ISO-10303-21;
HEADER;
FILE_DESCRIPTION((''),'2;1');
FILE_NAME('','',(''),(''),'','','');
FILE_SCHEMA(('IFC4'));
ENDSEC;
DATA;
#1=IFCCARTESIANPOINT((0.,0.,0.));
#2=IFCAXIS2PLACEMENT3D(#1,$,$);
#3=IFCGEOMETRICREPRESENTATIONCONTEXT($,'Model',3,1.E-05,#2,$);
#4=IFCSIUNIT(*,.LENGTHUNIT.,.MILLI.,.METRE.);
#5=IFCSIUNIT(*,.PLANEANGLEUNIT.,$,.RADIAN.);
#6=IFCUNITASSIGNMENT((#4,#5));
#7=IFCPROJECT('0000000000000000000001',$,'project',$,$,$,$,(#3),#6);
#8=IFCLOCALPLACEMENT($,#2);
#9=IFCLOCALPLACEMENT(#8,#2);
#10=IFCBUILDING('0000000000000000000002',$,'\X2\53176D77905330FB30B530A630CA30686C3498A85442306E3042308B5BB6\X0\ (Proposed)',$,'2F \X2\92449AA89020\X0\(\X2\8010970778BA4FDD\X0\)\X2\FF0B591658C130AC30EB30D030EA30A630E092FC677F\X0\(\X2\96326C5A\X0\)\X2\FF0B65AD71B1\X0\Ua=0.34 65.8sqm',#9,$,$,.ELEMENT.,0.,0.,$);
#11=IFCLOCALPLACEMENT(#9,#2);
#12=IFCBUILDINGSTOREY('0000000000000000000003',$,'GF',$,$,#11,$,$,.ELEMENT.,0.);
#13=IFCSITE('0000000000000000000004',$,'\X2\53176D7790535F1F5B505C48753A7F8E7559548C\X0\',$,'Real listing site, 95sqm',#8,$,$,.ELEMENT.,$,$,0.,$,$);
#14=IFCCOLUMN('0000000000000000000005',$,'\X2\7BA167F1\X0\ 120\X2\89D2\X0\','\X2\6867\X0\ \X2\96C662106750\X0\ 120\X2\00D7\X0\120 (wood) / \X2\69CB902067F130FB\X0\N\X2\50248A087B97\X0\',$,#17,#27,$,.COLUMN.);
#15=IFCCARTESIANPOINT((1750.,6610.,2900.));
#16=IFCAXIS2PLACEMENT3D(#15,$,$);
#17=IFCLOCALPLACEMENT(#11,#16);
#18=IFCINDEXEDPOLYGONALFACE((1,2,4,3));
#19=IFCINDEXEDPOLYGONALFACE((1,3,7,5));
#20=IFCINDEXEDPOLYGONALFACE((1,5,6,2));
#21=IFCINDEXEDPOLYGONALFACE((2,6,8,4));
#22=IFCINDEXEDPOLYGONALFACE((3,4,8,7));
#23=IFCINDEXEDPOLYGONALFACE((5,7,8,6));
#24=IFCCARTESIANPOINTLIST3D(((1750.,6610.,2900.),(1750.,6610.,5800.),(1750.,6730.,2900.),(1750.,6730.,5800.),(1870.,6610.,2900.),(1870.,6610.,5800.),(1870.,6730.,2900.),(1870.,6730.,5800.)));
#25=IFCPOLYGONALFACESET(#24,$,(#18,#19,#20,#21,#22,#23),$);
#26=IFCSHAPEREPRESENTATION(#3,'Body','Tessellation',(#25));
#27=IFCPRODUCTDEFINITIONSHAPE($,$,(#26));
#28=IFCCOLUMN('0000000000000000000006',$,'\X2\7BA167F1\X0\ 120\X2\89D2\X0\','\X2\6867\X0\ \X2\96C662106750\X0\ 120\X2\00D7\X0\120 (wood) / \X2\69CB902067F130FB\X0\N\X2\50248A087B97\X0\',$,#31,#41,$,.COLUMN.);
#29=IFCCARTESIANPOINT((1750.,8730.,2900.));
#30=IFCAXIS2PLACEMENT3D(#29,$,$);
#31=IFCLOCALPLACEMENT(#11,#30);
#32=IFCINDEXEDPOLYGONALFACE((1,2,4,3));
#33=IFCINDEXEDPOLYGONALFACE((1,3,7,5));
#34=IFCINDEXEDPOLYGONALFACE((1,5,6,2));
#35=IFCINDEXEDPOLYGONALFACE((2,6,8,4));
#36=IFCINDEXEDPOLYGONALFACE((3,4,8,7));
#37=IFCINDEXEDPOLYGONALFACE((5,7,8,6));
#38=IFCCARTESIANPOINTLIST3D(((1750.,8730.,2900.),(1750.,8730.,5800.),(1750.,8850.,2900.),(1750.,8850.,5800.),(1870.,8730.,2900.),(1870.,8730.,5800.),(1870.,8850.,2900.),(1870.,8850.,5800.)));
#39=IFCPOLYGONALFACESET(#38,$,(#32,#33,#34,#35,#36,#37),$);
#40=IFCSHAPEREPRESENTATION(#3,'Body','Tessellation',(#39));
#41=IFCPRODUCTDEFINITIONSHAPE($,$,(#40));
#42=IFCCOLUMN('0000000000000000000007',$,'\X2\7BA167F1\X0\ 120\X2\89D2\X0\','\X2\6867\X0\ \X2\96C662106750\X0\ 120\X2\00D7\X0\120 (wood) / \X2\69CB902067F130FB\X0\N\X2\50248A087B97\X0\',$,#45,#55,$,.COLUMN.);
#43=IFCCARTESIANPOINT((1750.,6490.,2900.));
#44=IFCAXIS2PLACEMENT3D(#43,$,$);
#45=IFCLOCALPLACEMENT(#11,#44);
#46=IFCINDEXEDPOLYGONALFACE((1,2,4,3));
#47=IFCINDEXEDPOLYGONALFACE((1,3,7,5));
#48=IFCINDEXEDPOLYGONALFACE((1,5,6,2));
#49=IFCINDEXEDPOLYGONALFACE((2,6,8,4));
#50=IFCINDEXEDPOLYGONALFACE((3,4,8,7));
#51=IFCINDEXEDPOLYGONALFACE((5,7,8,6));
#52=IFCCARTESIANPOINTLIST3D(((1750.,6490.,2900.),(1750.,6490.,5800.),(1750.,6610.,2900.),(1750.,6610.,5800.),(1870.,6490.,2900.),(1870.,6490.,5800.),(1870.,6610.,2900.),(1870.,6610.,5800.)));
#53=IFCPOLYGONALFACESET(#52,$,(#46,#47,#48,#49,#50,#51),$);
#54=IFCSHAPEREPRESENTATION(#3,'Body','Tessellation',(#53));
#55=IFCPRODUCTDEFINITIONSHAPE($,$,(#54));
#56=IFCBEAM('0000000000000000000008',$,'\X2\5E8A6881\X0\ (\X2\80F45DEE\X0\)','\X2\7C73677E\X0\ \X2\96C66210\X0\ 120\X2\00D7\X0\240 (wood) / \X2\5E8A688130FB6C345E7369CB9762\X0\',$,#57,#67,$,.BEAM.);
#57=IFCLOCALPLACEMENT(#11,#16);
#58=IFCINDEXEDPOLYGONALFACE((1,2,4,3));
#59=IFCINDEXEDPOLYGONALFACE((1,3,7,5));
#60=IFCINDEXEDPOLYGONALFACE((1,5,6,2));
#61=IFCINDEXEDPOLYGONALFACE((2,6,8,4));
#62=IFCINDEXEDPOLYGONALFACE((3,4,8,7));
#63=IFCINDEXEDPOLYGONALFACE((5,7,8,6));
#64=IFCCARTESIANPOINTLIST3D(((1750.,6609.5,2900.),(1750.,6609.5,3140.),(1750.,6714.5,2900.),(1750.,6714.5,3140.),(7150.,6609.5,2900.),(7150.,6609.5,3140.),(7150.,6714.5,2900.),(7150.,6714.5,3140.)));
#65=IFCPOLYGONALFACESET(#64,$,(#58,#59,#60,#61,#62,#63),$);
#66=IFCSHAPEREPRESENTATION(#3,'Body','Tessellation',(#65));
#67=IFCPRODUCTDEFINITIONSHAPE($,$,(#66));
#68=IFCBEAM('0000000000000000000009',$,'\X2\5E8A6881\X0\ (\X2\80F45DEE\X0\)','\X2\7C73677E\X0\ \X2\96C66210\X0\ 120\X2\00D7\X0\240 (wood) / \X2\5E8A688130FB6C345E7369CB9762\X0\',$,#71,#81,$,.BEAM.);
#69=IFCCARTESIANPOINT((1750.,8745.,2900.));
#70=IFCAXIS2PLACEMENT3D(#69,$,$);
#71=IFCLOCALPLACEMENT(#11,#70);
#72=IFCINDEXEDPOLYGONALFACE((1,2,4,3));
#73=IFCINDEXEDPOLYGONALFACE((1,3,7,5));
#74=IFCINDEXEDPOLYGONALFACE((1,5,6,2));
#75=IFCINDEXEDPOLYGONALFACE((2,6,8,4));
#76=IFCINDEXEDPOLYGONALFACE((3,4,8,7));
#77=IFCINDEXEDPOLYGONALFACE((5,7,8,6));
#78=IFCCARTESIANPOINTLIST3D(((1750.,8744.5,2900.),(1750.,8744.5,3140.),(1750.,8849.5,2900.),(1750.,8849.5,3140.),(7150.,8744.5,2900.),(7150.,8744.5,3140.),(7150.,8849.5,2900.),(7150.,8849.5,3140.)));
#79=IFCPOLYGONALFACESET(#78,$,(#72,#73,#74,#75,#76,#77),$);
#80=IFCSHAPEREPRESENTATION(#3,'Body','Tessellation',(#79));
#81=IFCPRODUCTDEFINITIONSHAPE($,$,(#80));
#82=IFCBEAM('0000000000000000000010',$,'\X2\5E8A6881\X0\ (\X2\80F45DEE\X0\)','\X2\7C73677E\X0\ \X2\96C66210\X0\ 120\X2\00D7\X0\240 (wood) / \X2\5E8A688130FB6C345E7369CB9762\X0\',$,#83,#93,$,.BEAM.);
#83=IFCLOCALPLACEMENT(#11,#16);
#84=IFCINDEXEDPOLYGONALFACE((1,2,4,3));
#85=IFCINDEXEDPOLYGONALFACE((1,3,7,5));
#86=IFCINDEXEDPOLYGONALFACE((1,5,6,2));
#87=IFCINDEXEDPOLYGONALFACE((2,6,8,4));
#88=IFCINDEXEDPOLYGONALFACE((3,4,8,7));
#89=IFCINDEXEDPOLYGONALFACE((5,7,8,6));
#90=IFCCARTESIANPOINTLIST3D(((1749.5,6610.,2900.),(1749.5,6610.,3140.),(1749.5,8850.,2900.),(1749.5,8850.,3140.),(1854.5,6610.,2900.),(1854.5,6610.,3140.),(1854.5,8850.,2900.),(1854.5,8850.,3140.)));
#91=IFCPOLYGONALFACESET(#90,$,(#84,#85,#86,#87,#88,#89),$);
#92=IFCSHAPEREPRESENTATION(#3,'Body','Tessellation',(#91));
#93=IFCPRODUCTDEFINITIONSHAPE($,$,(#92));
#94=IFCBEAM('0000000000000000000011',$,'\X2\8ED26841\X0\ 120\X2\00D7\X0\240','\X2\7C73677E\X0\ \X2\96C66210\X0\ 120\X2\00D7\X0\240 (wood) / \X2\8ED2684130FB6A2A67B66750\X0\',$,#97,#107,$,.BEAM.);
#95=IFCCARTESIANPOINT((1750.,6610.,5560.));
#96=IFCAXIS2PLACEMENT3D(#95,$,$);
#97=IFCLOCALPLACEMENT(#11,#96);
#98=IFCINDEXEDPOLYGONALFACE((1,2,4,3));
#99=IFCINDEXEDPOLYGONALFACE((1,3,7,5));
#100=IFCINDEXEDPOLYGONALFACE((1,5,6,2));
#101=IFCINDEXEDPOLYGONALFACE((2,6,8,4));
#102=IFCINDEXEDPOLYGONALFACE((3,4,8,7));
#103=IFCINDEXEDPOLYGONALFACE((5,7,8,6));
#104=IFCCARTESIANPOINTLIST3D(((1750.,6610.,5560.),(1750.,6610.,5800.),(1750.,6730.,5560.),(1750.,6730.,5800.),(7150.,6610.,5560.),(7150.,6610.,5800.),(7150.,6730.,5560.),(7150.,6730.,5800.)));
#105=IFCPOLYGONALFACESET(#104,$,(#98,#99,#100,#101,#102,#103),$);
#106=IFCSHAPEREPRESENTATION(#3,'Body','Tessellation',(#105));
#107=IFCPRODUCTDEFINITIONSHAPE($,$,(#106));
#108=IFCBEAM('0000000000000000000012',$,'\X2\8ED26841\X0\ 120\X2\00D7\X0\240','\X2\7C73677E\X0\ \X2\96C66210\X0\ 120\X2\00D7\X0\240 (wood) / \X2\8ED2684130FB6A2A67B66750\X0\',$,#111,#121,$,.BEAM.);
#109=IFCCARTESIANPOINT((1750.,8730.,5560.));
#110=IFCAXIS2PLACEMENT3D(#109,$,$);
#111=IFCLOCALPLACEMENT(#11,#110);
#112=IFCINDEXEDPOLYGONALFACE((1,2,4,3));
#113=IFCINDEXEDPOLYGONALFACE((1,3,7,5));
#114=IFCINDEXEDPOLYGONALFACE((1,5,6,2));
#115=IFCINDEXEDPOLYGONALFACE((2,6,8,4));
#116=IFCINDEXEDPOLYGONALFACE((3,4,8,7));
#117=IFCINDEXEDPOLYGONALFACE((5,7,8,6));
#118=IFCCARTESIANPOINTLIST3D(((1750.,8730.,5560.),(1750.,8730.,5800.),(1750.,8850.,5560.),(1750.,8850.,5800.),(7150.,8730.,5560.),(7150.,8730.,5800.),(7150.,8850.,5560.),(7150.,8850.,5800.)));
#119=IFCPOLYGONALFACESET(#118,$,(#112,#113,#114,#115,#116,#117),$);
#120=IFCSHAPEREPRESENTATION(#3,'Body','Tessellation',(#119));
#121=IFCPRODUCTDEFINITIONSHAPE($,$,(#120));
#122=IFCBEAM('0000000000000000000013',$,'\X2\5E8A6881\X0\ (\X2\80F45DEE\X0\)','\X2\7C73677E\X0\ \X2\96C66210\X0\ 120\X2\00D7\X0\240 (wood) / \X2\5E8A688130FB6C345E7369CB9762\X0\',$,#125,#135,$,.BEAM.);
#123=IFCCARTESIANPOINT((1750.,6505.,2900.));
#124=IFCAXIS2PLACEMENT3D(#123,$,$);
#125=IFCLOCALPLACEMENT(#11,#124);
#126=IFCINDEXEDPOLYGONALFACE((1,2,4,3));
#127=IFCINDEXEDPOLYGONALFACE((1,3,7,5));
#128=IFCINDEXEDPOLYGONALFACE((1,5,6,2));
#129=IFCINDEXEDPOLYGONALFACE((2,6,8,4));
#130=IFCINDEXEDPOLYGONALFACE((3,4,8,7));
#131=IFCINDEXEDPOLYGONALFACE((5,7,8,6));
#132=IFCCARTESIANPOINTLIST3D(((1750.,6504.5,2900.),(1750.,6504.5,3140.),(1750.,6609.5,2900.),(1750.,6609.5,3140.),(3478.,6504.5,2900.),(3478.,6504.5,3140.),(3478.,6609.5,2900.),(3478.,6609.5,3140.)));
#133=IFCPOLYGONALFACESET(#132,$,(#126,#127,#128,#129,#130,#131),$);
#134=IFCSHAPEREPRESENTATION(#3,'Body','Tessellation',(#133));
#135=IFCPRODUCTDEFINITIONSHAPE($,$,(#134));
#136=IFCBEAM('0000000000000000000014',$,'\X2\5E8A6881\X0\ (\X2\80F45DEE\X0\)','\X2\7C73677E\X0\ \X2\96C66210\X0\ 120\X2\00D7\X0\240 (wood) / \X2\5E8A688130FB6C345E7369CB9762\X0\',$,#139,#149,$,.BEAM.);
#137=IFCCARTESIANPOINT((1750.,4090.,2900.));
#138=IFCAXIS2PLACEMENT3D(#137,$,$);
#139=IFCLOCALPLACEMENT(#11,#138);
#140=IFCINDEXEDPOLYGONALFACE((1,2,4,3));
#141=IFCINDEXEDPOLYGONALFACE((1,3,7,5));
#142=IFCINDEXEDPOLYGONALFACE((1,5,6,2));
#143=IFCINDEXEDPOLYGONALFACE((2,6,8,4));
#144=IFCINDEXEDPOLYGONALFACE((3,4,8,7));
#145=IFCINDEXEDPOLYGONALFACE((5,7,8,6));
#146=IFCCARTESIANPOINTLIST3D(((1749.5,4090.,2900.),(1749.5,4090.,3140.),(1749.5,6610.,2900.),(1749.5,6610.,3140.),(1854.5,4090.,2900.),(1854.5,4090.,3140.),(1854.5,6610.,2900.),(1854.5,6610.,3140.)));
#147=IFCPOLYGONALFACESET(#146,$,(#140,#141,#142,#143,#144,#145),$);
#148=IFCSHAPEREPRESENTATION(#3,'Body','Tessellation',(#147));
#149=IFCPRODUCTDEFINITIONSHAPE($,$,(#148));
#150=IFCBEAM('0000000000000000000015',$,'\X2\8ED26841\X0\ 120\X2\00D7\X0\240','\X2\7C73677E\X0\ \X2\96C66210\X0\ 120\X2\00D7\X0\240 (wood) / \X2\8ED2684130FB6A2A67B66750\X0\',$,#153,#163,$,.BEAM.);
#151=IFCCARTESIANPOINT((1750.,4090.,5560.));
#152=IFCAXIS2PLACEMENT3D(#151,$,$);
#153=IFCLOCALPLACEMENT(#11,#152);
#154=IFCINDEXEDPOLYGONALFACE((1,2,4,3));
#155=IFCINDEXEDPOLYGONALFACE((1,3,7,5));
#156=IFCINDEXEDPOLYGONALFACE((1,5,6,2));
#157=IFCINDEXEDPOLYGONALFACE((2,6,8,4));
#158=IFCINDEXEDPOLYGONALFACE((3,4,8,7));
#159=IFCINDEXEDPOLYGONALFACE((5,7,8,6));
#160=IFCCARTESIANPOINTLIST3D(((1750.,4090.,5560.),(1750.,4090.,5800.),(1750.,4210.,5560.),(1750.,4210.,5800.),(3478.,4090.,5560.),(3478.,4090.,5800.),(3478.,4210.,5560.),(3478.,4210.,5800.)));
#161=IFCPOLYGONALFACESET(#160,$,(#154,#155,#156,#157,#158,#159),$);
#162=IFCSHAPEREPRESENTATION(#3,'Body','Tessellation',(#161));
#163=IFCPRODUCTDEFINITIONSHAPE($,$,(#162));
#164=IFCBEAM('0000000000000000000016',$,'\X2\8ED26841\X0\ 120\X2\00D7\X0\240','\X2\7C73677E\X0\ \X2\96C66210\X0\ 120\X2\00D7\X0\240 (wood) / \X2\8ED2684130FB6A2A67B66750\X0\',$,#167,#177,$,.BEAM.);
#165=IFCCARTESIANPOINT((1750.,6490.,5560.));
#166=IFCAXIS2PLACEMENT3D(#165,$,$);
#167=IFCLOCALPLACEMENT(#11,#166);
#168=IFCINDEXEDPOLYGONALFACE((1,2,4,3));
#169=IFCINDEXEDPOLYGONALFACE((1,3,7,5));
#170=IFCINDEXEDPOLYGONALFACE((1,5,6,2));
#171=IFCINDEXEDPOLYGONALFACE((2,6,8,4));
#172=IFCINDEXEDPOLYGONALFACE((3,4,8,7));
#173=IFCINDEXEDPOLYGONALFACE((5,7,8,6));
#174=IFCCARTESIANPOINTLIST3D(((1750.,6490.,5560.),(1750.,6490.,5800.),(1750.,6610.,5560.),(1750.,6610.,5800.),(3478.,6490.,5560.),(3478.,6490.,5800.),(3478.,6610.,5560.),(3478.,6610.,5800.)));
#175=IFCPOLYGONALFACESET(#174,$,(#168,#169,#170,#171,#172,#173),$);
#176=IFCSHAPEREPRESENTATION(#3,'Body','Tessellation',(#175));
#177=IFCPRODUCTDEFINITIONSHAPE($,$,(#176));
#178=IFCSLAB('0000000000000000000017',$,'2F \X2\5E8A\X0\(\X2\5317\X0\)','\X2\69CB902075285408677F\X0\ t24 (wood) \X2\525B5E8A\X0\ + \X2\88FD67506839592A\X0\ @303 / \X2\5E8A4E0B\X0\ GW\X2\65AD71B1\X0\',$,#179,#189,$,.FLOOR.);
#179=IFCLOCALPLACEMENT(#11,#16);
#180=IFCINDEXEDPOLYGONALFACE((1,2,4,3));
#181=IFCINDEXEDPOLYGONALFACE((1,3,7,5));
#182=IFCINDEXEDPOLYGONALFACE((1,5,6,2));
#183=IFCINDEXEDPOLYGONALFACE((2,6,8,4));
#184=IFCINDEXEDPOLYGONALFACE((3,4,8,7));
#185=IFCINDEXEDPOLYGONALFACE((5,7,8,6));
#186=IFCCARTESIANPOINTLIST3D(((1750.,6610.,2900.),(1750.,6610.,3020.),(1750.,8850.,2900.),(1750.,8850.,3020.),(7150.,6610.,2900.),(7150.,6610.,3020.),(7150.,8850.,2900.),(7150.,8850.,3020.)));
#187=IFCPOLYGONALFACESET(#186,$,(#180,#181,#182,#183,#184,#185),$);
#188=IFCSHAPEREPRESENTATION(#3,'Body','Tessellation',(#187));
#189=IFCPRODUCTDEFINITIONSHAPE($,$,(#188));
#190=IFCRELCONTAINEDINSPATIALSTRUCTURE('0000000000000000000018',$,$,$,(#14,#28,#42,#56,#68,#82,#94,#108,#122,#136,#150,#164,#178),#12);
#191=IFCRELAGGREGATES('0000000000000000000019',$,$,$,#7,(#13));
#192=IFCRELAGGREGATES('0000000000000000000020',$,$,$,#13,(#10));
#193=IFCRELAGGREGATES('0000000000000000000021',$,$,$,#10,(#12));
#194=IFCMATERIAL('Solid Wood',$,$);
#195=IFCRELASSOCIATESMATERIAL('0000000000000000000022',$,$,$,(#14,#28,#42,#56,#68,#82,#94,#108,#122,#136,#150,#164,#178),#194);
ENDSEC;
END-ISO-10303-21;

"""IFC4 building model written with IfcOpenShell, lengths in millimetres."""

from ifc_helpers import new_model, si_unit, frame, frame_2d, origin, place, context, project, spatial, rectangle, extrude, material, element, save


model = new_model("IFC4")

# Units and contexts
model_context = context("Model", 3, precision=1e-05, world=origin())
ifc_project = project(units=[si_unit("LENGTHUNIT", "METRE", prefix="MILLI"), si_unit("PLANEANGLEUNIT", "RADIAN")], contexts=[model_context])

# Site, building, storey
site_placement = place(None, origin())
site = spatial("IfcSite", under=ifc_project, at=site_placement, Name="北海道弟子屈町美留和", ObjectType="Real listing site, 95sqm", CompositionType="ELEMENT", RefElevation=0.0)
building_placement = place(site_placement, origin())
building = spatial("IfcBuilding", under=site, at=building_placement, Name="北海道・サウナと水風呂のある家 (Proposed)", ObjectType="2F 鉄骨造(耐震確保)＋外壁ガルバリウム鋼板(防汚)＋断熱Ua=0.34 65.8sqm", CompositionType="ELEMENT", ElevationOfRefHeight=0.0, ElevationOfTerrain=0.0)
storey_placement = place(building_placement, origin())
storey = spatial("IfcBuildingStorey", under=building, at=storey_placement, Name="GF", CompositionType="ELEMENT", Elevation=0.0)

# Columns
ifc_material_1 = material(Name="Solid Wood")
column_1_placement = place(storey_placement, frame((1750.0, 6610.0, 2900.0)))
element("IfcColumn", 1, at=column_1_placement, inside=storey, material=ifc_material_1, Name="管柱 120角", Description="桧 集成材 120×120 (wood) / 構造柱・N値計算", PredefinedType="COLUMN", context=model_context, shape_type="SweptSolid", body=[
    extrude(rectangle(XDim=120.0, YDim=120.0, at=frame_2d((60.0, 60.0))), frame((1750.0, 6610.0, 2900.0)), (0.0, 0.0, 1.0), 2900.0),
])
column_2_placement = place(storey_placement, frame((1750.0, 8730.0, 2900.0)))
element("IfcColumn", 2, at=column_2_placement, inside=storey, material=ifc_material_1, Name="管柱 120角", Description="桧 集成材 120×120 (wood) / 構造柱・N値計算", PredefinedType="COLUMN", context=model_context, shape_type="SweptSolid", body=[
    extrude(rectangle(XDim=120.0, YDim=120.0, at=frame_2d((60.0, 60.0))), frame((1750.0, 8730.0, 2900.0)), (0.0, 0.0, 1.0), 2900.0),
])
column_3_placement = place(storey_placement, frame((1750.0, 6490.0, 2900.0)))
element("IfcColumn", 3, at=column_3_placement, inside=storey, material=ifc_material_1, Name="管柱 120角", Description="桧 集成材 120×120 (wood) / 構造柱・N値計算", PredefinedType="COLUMN", context=model_context, shape_type="SweptSolid", body=[
    extrude(rectangle(XDim=120.0, YDim=120.0, at=frame_2d((60.0, 60.0))), frame((1750.0, 6490.0, 2900.0)), (0.0, 0.0, 1.0), 2900.0),
])

# Beams
beam_1_placement = place(storey_placement, frame((1750.0, 6610.0, 2900.0)))
element("IfcBeam", 4, at=beam_1_placement, inside=storey, material=ifc_material_1, Name="床梁 (胴差)", Description="米松 集成 120×240 (wood) / 床梁・水平構面", PredefinedType="BEAM", context=model_context, shape_type="SweptSolid", body=[
    extrude(rectangle(XDim=5400.0, YDim=105.0, at=frame_2d((2700.0, 52.0))), frame((1750.0, 6610.0, 2900.0)), (0.0, 0.0, 1.0), 240.0),
])
beam_2_placement = place(storey_placement, frame((1750.0, 8745.0, 2900.0)))
element("IfcBeam", 5, at=beam_2_placement, inside=storey, material=ifc_material_1, Name="床梁 (胴差)", Description="米松 集成 120×240 (wood) / 床梁・水平構面", PredefinedType="BEAM", context=model_context, shape_type="SweptSolid", body=[
    extrude(rectangle(XDim=5400.0, YDim=105.0, at=frame_2d((2700.0, 52.0))), frame((1750.0, 8745.0, 2900.0)), (0.0, 0.0, 1.0), 240.0),
])
beam_3_placement = place(storey_placement, frame((1750.0, 6610.0, 2900.0)))
element("IfcBeam", 6, at=beam_3_placement, inside=storey, material=ifc_material_1, Name="床梁 (胴差)", Description="米松 集成 120×240 (wood) / 床梁・水平構面", PredefinedType="BEAM", context=model_context, shape_type="SweptSolid", body=[
    extrude(rectangle(XDim=105.0, YDim=2240.0, at=frame_2d((52.0, 1120.0))), frame((1750.0, 6610.0, 2900.0)), (0.0, 0.0, 1.0), 240.0),
])
beam_4_placement = place(storey_placement, frame((1750.0, 6610.0, 5560.0)))
element("IfcBeam", 7, at=beam_4_placement, inside=storey, material=ifc_material_1, Name="軒桁 120×240", Description="米松 集成 120×240 (wood) / 軒桁・横架材", PredefinedType="BEAM", context=model_context, shape_type="SweptSolid", body=[
    extrude(rectangle(XDim=5400.0, YDim=120.0, at=frame_2d((2700.0, 60.0))), frame((1750.0, 6610.0, 5560.0)), (0.0, 0.0, 1.0), 240.0),
])
beam_5_placement = place(storey_placement, frame((1750.0, 8730.0, 5560.0)))
element("IfcBeam", 8, at=beam_5_placement, inside=storey, material=ifc_material_1, Name="軒桁 120×240", Description="米松 集成 120×240 (wood) / 軒桁・横架材", PredefinedType="BEAM", context=model_context, shape_type="SweptSolid", body=[
    extrude(rectangle(XDim=5400.0, YDim=120.0, at=frame_2d((2700.0, 60.0))), frame((1750.0, 8730.0, 5560.0)), (0.0, 0.0, 1.0), 240.0),
])
beam_6_placement = place(storey_placement, frame((1750.0, 6505.0, 2900.0)))
element("IfcBeam", 9, at=beam_6_placement, inside=storey, material=ifc_material_1, Name="床梁 (胴差)", Description="米松 集成 120×240 (wood) / 床梁・水平構面", PredefinedType="BEAM", context=model_context, shape_type="SweptSolid", body=[
    extrude(rectangle(XDim=1728.0, YDim=105.0, at=frame_2d((864.0, 52.0))), frame((1750.0, 6505.0, 2900.0)), (0.0, 0.0, 1.0), 240.0),
])
beam_7_placement = place(storey_placement, frame((1750.0, 4090.0, 2900.0)))
element("IfcBeam", 10, at=beam_7_placement, inside=storey, material=ifc_material_1, Name="床梁 (胴差)", Description="米松 集成 120×240 (wood) / 床梁・水平構面", PredefinedType="BEAM", context=model_context, shape_type="SweptSolid", body=[
    extrude(rectangle(XDim=105.0, YDim=2520.0, at=frame_2d((52.0, 1260.0))), frame((1750.0, 4090.0, 2900.0)), (0.0, 0.0, 1.0), 240.0),
])
beam_8_placement = place(storey_placement, frame((1750.0, 4090.0, 5560.0)))
element("IfcBeam", 11, at=beam_8_placement, inside=storey, material=ifc_material_1, Name="軒桁 120×240", Description="米松 集成 120×240 (wood) / 軒桁・横架材", PredefinedType="BEAM", context=model_context, shape_type="SweptSolid", body=[
    extrude(rectangle(XDim=1728.0, YDim=120.0, at=frame_2d((864.0, 60.0))), frame((1750.0, 4090.0, 5560.0)), (0.0, 0.0, 1.0), 240.0),
])
beam_9_placement = place(storey_placement, frame((1750.0, 6490.0, 5560.0)))
element("IfcBeam", 12, at=beam_9_placement, inside=storey, material=ifc_material_1, Name="軒桁 120×240", Description="米松 集成 120×240 (wood) / 軒桁・横架材", PredefinedType="BEAM", context=model_context, shape_type="SweptSolid", body=[
    extrude(rectangle(XDim=1728.0, YDim=120.0, at=frame_2d((864.0, 60.0))), frame((1750.0, 6490.0, 5560.0)), (0.0, 0.0, 1.0), 240.0),
])

# Slab
slab_placement = place(storey_placement, frame((1750.0, 6610.0, 2900.0)))
element("IfcSlab", 13, at=slab_placement, inside=storey, material=ifc_material_1, Name="2F 床(北)", Description="構造用合板 t24 (wood) 剛床 + 製材根太 @303 / 床下 GW断熱", PredefinedType="FLOOR", context=model_context, shape_type="SweptSolid", body=[
    extrude(rectangle(XDim=5400.0, YDim=2240.0, at=frame_2d((2700.0, 1120.0))), frame((1750.0, 6610.0, 2900.0)), (0.0, 0.0, 1.0), 120.0),
])

save(model, "model.ifc")
